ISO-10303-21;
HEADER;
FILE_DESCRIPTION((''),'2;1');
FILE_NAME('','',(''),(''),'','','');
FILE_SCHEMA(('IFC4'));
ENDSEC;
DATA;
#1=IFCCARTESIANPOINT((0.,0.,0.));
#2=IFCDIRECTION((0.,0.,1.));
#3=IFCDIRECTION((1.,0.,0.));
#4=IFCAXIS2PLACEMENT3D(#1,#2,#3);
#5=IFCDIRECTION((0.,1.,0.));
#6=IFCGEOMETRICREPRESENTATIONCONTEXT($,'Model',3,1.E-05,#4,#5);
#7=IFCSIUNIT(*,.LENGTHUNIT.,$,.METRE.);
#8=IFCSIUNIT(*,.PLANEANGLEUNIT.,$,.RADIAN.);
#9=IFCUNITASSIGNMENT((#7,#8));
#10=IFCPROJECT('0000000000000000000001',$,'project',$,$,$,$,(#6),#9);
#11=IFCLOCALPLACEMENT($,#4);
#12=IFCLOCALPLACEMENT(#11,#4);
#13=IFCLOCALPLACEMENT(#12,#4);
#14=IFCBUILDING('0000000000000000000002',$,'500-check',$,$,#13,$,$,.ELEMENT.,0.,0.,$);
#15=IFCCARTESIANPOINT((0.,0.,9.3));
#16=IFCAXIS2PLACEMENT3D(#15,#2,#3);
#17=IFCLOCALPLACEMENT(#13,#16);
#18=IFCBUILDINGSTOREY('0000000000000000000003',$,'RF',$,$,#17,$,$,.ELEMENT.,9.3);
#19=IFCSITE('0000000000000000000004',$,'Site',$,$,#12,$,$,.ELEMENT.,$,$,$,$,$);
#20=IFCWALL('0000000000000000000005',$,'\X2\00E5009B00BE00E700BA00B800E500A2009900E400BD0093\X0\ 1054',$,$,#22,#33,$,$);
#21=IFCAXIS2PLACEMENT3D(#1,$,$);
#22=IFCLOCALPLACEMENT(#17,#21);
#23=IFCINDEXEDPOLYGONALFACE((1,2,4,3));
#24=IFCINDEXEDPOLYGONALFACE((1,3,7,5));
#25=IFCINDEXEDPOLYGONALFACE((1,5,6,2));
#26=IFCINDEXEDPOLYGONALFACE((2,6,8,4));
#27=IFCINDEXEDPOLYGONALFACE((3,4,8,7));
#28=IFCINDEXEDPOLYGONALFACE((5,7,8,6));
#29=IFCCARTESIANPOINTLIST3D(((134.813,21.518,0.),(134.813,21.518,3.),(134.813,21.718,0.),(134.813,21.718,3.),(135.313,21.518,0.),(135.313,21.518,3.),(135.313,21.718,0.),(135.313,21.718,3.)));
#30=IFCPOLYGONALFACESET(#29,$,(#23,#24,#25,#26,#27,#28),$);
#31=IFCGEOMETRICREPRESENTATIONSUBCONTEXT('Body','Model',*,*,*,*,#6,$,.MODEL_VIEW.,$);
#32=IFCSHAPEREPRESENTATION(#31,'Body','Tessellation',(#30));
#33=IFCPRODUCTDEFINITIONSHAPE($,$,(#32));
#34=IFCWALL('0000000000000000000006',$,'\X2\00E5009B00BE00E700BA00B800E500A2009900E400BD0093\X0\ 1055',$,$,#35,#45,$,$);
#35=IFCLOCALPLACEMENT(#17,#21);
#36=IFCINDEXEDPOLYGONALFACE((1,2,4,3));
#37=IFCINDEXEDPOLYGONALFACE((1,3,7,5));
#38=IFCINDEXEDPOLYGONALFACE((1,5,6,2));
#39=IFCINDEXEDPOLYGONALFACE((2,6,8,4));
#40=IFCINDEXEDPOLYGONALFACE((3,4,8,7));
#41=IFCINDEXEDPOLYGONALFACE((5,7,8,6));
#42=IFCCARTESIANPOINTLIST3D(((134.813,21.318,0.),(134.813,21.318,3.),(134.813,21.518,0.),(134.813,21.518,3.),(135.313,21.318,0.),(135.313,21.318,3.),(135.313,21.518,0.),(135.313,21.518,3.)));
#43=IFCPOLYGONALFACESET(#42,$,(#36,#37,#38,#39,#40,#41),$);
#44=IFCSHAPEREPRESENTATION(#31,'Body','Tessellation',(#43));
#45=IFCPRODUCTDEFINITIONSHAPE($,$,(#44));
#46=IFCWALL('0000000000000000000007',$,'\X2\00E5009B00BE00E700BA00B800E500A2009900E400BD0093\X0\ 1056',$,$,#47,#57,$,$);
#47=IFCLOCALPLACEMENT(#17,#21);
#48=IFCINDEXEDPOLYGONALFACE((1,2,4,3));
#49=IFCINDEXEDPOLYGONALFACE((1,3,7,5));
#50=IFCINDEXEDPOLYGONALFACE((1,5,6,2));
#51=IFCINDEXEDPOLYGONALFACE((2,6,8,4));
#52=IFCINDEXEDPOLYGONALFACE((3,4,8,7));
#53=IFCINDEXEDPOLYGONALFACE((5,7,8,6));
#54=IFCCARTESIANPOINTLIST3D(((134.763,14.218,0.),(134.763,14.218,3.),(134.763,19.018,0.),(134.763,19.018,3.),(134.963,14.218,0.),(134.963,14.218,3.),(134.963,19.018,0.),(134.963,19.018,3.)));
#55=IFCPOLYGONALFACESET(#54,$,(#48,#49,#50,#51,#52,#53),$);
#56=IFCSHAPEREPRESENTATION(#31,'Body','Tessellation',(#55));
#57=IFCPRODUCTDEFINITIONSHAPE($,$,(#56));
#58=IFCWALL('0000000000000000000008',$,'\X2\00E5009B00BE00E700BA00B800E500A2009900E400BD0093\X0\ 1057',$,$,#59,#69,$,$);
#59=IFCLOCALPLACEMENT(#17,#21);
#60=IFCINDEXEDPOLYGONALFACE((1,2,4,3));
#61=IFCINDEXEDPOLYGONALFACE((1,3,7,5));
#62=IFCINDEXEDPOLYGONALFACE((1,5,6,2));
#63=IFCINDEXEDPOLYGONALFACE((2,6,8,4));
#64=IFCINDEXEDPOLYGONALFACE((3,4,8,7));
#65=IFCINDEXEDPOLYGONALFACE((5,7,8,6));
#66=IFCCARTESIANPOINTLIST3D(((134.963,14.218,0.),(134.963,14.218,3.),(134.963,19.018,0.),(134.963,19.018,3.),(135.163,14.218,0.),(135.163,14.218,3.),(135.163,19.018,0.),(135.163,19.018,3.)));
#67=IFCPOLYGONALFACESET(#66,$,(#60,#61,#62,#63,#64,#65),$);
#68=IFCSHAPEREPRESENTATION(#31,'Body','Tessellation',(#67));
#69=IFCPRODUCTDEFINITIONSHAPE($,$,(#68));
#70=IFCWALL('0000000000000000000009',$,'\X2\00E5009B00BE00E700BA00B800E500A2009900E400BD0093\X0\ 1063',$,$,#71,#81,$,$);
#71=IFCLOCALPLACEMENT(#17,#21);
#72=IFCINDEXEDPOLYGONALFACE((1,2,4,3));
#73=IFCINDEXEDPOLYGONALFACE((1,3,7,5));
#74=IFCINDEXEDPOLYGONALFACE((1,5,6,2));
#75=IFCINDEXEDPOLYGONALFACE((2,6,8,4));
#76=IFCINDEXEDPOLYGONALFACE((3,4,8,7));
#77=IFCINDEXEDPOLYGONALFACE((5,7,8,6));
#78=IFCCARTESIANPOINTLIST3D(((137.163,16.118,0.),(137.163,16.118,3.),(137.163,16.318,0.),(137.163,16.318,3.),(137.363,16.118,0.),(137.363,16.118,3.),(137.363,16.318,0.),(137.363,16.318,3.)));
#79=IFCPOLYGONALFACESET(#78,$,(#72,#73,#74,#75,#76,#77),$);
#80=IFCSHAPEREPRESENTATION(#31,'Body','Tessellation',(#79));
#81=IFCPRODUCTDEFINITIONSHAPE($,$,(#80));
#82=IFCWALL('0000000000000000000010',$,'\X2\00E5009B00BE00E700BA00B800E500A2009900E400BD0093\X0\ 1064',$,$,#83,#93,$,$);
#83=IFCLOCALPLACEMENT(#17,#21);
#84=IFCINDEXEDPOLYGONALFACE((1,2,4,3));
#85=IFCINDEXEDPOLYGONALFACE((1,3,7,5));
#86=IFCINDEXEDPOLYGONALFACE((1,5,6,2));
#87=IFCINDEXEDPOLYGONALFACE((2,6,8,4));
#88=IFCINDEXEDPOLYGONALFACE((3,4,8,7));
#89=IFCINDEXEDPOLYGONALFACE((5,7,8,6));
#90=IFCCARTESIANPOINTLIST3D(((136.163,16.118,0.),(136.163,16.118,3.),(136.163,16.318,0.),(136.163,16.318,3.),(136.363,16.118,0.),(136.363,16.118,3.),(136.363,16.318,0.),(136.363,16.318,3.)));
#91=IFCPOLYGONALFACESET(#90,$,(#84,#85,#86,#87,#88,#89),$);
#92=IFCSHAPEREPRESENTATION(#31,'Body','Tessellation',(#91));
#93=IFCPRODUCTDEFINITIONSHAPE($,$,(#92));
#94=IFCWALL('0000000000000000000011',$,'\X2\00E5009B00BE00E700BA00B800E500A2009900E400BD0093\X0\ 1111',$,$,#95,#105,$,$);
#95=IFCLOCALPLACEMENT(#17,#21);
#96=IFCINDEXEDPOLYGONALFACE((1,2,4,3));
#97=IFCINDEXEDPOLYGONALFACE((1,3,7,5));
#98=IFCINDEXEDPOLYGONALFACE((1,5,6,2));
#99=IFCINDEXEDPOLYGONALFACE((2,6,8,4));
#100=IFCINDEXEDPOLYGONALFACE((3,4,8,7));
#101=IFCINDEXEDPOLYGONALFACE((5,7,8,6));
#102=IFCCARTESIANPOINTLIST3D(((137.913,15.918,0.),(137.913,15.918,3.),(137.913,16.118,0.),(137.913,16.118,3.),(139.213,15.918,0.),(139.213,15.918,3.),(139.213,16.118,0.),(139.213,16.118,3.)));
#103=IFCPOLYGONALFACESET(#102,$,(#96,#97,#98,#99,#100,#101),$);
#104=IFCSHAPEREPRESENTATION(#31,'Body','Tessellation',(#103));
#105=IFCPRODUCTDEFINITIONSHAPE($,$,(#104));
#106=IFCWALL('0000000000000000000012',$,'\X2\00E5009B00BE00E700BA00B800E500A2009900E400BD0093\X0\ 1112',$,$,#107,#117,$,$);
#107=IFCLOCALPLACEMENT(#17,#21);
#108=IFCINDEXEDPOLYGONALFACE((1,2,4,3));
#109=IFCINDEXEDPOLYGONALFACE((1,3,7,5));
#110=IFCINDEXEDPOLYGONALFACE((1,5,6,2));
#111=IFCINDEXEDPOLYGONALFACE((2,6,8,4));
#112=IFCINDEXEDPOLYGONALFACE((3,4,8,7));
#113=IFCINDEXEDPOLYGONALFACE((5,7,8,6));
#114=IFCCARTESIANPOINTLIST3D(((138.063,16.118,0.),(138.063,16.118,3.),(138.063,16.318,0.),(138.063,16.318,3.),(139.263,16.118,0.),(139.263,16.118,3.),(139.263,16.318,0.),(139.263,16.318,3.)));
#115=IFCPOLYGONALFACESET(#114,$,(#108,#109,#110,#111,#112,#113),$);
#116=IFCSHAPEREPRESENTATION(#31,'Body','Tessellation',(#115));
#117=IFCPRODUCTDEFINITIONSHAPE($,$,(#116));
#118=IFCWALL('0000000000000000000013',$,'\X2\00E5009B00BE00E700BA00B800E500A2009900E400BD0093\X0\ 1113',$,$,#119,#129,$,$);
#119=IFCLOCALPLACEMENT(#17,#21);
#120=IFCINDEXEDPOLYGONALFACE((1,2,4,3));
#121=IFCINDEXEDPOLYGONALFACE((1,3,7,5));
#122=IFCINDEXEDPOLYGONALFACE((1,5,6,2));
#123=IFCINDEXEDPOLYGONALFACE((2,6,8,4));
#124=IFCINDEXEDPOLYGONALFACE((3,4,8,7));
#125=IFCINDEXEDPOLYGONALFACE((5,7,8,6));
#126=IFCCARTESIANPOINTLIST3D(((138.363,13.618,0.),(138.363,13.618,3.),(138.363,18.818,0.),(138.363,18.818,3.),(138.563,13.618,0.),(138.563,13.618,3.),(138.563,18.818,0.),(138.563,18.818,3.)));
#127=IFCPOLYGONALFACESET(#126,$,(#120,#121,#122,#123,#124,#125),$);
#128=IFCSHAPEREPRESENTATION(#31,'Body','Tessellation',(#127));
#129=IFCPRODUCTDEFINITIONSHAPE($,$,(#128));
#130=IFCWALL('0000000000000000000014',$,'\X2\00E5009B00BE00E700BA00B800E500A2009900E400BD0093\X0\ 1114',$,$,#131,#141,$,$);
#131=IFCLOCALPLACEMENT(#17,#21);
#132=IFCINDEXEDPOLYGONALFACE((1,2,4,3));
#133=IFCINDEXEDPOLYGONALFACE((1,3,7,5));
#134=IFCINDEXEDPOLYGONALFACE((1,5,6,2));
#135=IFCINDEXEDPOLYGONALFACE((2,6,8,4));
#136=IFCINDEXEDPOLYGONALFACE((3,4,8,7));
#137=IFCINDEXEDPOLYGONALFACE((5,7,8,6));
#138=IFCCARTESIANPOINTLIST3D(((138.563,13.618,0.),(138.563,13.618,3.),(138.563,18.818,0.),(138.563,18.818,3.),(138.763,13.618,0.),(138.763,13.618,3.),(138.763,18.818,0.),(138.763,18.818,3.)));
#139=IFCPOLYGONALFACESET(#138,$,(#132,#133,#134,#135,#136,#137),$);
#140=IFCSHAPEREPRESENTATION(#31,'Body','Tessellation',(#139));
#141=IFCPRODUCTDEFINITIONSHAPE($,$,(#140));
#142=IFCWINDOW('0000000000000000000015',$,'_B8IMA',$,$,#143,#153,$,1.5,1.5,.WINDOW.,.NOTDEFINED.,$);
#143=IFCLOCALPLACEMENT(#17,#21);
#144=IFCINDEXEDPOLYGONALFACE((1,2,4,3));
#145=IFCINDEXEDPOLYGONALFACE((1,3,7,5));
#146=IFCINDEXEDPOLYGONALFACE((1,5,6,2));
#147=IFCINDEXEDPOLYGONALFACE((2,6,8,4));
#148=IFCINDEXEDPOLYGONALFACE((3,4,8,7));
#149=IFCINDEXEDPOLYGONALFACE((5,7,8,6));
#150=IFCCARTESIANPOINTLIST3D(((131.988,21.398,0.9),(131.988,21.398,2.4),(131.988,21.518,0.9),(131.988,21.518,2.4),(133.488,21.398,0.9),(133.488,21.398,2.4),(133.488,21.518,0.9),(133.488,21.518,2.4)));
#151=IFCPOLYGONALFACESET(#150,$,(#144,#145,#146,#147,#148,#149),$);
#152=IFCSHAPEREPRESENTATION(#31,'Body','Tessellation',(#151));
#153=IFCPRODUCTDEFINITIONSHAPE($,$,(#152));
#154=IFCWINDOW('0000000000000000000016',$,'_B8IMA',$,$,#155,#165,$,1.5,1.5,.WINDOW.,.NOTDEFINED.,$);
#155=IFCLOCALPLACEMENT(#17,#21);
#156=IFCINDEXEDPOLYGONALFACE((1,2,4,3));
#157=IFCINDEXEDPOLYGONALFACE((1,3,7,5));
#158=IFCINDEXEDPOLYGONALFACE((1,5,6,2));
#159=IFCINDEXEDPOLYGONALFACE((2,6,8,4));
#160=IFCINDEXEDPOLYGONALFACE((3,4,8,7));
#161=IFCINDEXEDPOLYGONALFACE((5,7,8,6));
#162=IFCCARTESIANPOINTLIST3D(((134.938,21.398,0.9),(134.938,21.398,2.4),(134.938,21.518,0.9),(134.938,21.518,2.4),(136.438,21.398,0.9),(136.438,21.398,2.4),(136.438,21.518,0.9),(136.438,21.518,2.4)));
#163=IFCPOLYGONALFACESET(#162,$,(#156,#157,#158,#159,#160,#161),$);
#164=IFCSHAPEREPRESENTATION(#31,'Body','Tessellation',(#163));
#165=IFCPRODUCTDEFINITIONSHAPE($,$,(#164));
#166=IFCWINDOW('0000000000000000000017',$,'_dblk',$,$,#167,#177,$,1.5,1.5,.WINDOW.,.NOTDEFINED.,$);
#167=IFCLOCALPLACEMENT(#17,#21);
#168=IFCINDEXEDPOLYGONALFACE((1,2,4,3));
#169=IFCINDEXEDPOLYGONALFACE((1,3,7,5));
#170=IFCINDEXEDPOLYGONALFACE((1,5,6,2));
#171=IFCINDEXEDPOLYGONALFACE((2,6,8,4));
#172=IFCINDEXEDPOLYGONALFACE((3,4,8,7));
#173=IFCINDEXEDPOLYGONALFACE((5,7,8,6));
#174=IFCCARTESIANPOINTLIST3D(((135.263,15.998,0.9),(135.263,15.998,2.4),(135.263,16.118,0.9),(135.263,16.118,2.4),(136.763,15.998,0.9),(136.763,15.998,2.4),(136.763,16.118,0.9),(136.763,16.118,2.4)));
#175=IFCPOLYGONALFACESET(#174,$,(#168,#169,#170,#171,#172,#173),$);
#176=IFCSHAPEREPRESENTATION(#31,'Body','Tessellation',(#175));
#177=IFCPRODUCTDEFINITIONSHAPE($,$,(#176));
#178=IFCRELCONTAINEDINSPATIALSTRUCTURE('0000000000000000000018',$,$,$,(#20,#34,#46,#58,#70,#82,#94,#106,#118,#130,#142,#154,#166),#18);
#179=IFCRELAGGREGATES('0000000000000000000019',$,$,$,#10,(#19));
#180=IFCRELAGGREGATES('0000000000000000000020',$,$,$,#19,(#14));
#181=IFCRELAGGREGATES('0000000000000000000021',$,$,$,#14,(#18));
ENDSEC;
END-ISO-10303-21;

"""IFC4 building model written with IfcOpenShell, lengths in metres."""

from ifc_helpers import new_model, si_unit, direction, frame, frame_2d, origin_with_axes, place, context, subcontext, project, spatial, rectangle, extrude, element, save


model = new_model("IFC4")

# Units and contexts
model_context = context("Model", 3, precision=1e-05, world=origin_with_axes(), true_north=direction((0.0, 1.0, 0.0)))
body_context = subcontext(model_context, "Body", "Model", "MODEL_VIEW")
ifc_project = project(units=[si_unit("LENGTHUNIT", "METRE"), si_unit("PLANEANGLEUNIT", "RADIAN")], contexts=[model_context])

# Site, building, storey
placement = place(None, origin_with_axes())
site_placement = place(placement, origin_with_axes())
site = spatial("IfcSite", under=ifc_project, at=site_placement, Name="Site", CompositionType="ELEMENT")
building_placement = place(site_placement, origin_with_axes())
building = spatial("IfcBuilding", under=site, at=building_placement, Name="500-check", CompositionType="ELEMENT", ElevationOfRefHeight=0.0, ElevationOfTerrain=0.0)
storey_placement = place(building_placement, frame((0.0, 0.0, 9.3), z_axis=(0.0, 0.0, 1.0), x_axis=(1.0, 0.0, 0.0)))
storey = spatial("IfcBuildingStorey", under=building, at=storey_placement, Name="RF", CompositionType="ELEMENT", Elevation=9.3)

# Walls
for number, where, z_axis, x_axis, name in (
    (1, (135.063, 21.618, 0.0), (0.0, 0.0, 1.0), (1.0, 0.0, 0.0), "å\u009b¾çº¸å¢\u0099ä½\u0093 1054"),
    (2, (135.063, 21.418, 0.0), (0.0, 0.0, 1.0), (1.0, 0.0, 0.0), "å\u009b¾çº¸å¢\u0099ä½\u0093 1055"),
):
    element("IfcWall", number, at=place(storey_placement, frame(where, z_axis=z_axis, x_axis=x_axis)), inside=storey, Name=name, context=body_context, shape_type="SweptSolid", body=[
        extrude(rectangle(XDim=0.5, YDim=0.2, at=frame_2d((0.0, 0.0), x_axis=(1.0, 0.0, 0.0))), frame((0.0, 0.0, 0.0), z_axis=(0.0, 0.0, 1.0)), (0.0, 0.0, 1.0), 3.0),
    ])
for number, where, z_axis, x_axis, name in (
    (3, (134.863, 16.618, 0.0), (0.0, 0.0, 1.0), (0.0, 1.0, 0.0), "å\u009b¾çº¸å¢\u0099ä½\u0093 1056"),
    (4, (135.063, 16.618, 0.0), (0.0, 0.0, 1.0), (0.0, 1.0, 0.0), "å\u009b¾çº¸å¢\u0099ä½\u0093 1057"),
):
    element("IfcWall", number, at=place(storey_placement, frame(where, z_axis=z_axis, x_axis=x_axis)), inside=storey, Name=name, context=body_context, shape_type="SweptSolid", body=[
        extrude(rectangle(XDim=4.8, YDim=0.2, at=frame_2d((0.0, 0.0), x_axis=(1.0, 0.0, 0.0))), frame((0.0, 0.0, 0.0), z_axis=(0.0, 0.0, 1.0)), (0.0, 0.0, 1.0), 3.0),
    ])
for number, where, z_axis, x_axis, name in (
    (5, (137.263, 16.218, 0.0), (0.0, 0.0, 1.0), (0.0, -1.0, 0.0), "å\u009b¾çº¸å¢\u0099ä½\u0093 1063"),
    (6, (136.263, 16.218, 0.0), (0.0, 0.0, 1.0), (0.0, -1.0, 0.0), "å\u009b¾çº¸å¢\u0099ä½\u0093 1064"),
):
    element("IfcWall", number, at=place(storey_placement, frame(where, z_axis=z_axis, x_axis=x_axis)), inside=storey, Name=name, context=body_context, shape_type="SweptSolid", body=[
        extrude(rectangle(XDim=0.2, YDim=0.2, at=frame_2d((0.0, 0.0), x_axis=(1.0, 0.0, 0.0))), frame((0.0, 0.0, 0.0), z_axis=(0.0, 0.0, 1.0)), (0.0, 0.0, 1.0), 3.0),
    ])
wall_1_placement = place(storey_placement, frame((138.563, 16.018, 0.0), z_axis=(0.0, 0.0, 1.0), x_axis=(1.0, 0.0, 0.0)))
element("IfcWall", 7, at=wall_1_placement, inside=storey, Name="å\u009b¾çº¸å¢\u0099ä½\u0093 1111", context=body_context, shape_type="SweptSolid", body=[
    extrude(rectangle(XDim=1.3, YDim=0.2, at=frame_2d((0.0, 0.0), x_axis=(1.0, 0.0, 0.0))), frame((0.0, 0.0, 0.0), z_axis=(0.0, 0.0, 1.0)), (0.0, 0.0, 1.0), 3.0),
])
wall_2_placement = place(storey_placement, frame((138.663, 16.218, 0.0), z_axis=(0.0, 0.0, 1.0), x_axis=(1.0, 0.0, 0.0)))
element("IfcWall", 8, at=wall_2_placement, inside=storey, Name="å\u009b¾çº¸å¢\u0099ä½\u0093 1112", context=body_context, shape_type="SweptSolid", body=[
    extrude(rectangle(XDim=1.2, YDim=0.2, at=frame_2d((0.0, 0.0), x_axis=(1.0, 0.0, 0.0))), frame((0.0, 0.0, 0.0), z_axis=(0.0, 0.0, 1.0)), (0.0, 0.0, 1.0), 3.0),
])
for number, where, z_axis, x_axis, name in (
    (9, (138.463, 16.218, 0.0), (0.0, 0.0, 1.0), (0.0, 1.0, 0.0), "å\u009b¾çº¸å¢\u0099ä½\u0093 1113"),
    (10, (138.663, 16.218, 0.0), (0.0, 0.0, 1.0), (0.0, 1.0, 0.0), "å\u009b¾çº¸å¢\u0099ä½\u0093 1114"),
):
    element("IfcWall", number, at=place(storey_placement, frame(where, z_axis=z_axis, x_axis=x_axis)), inside=storey, Name=name, context=body_context, shape_type="SweptSolid", body=[
        extrude(rectangle(XDim=5.2, YDim=0.2, at=frame_2d((0.0, 0.0), x_axis=(1.0, 0.0, 0.0))), frame((0.0, 0.0, 0.0), z_axis=(0.0, 0.0, 1.0)), (0.0, 0.0, 1.0), 3.0),
    ])

# Windows
for number, where, z_axis, x_axis, name in (
    (11, (132.738, 21.458, 0.9), (0.0, 0.0, 1.0), (1.0, 0.0, 0.0), "_B8IMA"),
    (12, (135.688, 21.458, 0.9), (0.0, 0.0, 1.0), (1.0, 0.0, 0.0), "_B8IMA"),
    (13, (136.013, 16.058, 0.9), (0.0, 0.0, 1.0), (1.0, 0.0, 0.0), "_dblk"),
):
    element("IfcWindow", number, at=place(storey_placement, frame(where, z_axis=z_axis, x_axis=x_axis)), inside=storey, Name=name, OverallHeight=1.5, OverallWidth=1.5, PartitioningType="NOTDEFINED", PredefinedType="WINDOW", context=body_context, shape_type="SweptSolid", body=[
        extrude(rectangle(XDim=1.5, YDim=0.12, at=frame_2d((0.0, 0.0), x_axis=(1.0, 0.0, 0.0))), frame((0.0, 0.0, 0.0), z_axis=(0.0, 0.0, 1.0)), (0.0, 0.0, 1.0), 1.5),
    ])

save(model, "model.ifc")
